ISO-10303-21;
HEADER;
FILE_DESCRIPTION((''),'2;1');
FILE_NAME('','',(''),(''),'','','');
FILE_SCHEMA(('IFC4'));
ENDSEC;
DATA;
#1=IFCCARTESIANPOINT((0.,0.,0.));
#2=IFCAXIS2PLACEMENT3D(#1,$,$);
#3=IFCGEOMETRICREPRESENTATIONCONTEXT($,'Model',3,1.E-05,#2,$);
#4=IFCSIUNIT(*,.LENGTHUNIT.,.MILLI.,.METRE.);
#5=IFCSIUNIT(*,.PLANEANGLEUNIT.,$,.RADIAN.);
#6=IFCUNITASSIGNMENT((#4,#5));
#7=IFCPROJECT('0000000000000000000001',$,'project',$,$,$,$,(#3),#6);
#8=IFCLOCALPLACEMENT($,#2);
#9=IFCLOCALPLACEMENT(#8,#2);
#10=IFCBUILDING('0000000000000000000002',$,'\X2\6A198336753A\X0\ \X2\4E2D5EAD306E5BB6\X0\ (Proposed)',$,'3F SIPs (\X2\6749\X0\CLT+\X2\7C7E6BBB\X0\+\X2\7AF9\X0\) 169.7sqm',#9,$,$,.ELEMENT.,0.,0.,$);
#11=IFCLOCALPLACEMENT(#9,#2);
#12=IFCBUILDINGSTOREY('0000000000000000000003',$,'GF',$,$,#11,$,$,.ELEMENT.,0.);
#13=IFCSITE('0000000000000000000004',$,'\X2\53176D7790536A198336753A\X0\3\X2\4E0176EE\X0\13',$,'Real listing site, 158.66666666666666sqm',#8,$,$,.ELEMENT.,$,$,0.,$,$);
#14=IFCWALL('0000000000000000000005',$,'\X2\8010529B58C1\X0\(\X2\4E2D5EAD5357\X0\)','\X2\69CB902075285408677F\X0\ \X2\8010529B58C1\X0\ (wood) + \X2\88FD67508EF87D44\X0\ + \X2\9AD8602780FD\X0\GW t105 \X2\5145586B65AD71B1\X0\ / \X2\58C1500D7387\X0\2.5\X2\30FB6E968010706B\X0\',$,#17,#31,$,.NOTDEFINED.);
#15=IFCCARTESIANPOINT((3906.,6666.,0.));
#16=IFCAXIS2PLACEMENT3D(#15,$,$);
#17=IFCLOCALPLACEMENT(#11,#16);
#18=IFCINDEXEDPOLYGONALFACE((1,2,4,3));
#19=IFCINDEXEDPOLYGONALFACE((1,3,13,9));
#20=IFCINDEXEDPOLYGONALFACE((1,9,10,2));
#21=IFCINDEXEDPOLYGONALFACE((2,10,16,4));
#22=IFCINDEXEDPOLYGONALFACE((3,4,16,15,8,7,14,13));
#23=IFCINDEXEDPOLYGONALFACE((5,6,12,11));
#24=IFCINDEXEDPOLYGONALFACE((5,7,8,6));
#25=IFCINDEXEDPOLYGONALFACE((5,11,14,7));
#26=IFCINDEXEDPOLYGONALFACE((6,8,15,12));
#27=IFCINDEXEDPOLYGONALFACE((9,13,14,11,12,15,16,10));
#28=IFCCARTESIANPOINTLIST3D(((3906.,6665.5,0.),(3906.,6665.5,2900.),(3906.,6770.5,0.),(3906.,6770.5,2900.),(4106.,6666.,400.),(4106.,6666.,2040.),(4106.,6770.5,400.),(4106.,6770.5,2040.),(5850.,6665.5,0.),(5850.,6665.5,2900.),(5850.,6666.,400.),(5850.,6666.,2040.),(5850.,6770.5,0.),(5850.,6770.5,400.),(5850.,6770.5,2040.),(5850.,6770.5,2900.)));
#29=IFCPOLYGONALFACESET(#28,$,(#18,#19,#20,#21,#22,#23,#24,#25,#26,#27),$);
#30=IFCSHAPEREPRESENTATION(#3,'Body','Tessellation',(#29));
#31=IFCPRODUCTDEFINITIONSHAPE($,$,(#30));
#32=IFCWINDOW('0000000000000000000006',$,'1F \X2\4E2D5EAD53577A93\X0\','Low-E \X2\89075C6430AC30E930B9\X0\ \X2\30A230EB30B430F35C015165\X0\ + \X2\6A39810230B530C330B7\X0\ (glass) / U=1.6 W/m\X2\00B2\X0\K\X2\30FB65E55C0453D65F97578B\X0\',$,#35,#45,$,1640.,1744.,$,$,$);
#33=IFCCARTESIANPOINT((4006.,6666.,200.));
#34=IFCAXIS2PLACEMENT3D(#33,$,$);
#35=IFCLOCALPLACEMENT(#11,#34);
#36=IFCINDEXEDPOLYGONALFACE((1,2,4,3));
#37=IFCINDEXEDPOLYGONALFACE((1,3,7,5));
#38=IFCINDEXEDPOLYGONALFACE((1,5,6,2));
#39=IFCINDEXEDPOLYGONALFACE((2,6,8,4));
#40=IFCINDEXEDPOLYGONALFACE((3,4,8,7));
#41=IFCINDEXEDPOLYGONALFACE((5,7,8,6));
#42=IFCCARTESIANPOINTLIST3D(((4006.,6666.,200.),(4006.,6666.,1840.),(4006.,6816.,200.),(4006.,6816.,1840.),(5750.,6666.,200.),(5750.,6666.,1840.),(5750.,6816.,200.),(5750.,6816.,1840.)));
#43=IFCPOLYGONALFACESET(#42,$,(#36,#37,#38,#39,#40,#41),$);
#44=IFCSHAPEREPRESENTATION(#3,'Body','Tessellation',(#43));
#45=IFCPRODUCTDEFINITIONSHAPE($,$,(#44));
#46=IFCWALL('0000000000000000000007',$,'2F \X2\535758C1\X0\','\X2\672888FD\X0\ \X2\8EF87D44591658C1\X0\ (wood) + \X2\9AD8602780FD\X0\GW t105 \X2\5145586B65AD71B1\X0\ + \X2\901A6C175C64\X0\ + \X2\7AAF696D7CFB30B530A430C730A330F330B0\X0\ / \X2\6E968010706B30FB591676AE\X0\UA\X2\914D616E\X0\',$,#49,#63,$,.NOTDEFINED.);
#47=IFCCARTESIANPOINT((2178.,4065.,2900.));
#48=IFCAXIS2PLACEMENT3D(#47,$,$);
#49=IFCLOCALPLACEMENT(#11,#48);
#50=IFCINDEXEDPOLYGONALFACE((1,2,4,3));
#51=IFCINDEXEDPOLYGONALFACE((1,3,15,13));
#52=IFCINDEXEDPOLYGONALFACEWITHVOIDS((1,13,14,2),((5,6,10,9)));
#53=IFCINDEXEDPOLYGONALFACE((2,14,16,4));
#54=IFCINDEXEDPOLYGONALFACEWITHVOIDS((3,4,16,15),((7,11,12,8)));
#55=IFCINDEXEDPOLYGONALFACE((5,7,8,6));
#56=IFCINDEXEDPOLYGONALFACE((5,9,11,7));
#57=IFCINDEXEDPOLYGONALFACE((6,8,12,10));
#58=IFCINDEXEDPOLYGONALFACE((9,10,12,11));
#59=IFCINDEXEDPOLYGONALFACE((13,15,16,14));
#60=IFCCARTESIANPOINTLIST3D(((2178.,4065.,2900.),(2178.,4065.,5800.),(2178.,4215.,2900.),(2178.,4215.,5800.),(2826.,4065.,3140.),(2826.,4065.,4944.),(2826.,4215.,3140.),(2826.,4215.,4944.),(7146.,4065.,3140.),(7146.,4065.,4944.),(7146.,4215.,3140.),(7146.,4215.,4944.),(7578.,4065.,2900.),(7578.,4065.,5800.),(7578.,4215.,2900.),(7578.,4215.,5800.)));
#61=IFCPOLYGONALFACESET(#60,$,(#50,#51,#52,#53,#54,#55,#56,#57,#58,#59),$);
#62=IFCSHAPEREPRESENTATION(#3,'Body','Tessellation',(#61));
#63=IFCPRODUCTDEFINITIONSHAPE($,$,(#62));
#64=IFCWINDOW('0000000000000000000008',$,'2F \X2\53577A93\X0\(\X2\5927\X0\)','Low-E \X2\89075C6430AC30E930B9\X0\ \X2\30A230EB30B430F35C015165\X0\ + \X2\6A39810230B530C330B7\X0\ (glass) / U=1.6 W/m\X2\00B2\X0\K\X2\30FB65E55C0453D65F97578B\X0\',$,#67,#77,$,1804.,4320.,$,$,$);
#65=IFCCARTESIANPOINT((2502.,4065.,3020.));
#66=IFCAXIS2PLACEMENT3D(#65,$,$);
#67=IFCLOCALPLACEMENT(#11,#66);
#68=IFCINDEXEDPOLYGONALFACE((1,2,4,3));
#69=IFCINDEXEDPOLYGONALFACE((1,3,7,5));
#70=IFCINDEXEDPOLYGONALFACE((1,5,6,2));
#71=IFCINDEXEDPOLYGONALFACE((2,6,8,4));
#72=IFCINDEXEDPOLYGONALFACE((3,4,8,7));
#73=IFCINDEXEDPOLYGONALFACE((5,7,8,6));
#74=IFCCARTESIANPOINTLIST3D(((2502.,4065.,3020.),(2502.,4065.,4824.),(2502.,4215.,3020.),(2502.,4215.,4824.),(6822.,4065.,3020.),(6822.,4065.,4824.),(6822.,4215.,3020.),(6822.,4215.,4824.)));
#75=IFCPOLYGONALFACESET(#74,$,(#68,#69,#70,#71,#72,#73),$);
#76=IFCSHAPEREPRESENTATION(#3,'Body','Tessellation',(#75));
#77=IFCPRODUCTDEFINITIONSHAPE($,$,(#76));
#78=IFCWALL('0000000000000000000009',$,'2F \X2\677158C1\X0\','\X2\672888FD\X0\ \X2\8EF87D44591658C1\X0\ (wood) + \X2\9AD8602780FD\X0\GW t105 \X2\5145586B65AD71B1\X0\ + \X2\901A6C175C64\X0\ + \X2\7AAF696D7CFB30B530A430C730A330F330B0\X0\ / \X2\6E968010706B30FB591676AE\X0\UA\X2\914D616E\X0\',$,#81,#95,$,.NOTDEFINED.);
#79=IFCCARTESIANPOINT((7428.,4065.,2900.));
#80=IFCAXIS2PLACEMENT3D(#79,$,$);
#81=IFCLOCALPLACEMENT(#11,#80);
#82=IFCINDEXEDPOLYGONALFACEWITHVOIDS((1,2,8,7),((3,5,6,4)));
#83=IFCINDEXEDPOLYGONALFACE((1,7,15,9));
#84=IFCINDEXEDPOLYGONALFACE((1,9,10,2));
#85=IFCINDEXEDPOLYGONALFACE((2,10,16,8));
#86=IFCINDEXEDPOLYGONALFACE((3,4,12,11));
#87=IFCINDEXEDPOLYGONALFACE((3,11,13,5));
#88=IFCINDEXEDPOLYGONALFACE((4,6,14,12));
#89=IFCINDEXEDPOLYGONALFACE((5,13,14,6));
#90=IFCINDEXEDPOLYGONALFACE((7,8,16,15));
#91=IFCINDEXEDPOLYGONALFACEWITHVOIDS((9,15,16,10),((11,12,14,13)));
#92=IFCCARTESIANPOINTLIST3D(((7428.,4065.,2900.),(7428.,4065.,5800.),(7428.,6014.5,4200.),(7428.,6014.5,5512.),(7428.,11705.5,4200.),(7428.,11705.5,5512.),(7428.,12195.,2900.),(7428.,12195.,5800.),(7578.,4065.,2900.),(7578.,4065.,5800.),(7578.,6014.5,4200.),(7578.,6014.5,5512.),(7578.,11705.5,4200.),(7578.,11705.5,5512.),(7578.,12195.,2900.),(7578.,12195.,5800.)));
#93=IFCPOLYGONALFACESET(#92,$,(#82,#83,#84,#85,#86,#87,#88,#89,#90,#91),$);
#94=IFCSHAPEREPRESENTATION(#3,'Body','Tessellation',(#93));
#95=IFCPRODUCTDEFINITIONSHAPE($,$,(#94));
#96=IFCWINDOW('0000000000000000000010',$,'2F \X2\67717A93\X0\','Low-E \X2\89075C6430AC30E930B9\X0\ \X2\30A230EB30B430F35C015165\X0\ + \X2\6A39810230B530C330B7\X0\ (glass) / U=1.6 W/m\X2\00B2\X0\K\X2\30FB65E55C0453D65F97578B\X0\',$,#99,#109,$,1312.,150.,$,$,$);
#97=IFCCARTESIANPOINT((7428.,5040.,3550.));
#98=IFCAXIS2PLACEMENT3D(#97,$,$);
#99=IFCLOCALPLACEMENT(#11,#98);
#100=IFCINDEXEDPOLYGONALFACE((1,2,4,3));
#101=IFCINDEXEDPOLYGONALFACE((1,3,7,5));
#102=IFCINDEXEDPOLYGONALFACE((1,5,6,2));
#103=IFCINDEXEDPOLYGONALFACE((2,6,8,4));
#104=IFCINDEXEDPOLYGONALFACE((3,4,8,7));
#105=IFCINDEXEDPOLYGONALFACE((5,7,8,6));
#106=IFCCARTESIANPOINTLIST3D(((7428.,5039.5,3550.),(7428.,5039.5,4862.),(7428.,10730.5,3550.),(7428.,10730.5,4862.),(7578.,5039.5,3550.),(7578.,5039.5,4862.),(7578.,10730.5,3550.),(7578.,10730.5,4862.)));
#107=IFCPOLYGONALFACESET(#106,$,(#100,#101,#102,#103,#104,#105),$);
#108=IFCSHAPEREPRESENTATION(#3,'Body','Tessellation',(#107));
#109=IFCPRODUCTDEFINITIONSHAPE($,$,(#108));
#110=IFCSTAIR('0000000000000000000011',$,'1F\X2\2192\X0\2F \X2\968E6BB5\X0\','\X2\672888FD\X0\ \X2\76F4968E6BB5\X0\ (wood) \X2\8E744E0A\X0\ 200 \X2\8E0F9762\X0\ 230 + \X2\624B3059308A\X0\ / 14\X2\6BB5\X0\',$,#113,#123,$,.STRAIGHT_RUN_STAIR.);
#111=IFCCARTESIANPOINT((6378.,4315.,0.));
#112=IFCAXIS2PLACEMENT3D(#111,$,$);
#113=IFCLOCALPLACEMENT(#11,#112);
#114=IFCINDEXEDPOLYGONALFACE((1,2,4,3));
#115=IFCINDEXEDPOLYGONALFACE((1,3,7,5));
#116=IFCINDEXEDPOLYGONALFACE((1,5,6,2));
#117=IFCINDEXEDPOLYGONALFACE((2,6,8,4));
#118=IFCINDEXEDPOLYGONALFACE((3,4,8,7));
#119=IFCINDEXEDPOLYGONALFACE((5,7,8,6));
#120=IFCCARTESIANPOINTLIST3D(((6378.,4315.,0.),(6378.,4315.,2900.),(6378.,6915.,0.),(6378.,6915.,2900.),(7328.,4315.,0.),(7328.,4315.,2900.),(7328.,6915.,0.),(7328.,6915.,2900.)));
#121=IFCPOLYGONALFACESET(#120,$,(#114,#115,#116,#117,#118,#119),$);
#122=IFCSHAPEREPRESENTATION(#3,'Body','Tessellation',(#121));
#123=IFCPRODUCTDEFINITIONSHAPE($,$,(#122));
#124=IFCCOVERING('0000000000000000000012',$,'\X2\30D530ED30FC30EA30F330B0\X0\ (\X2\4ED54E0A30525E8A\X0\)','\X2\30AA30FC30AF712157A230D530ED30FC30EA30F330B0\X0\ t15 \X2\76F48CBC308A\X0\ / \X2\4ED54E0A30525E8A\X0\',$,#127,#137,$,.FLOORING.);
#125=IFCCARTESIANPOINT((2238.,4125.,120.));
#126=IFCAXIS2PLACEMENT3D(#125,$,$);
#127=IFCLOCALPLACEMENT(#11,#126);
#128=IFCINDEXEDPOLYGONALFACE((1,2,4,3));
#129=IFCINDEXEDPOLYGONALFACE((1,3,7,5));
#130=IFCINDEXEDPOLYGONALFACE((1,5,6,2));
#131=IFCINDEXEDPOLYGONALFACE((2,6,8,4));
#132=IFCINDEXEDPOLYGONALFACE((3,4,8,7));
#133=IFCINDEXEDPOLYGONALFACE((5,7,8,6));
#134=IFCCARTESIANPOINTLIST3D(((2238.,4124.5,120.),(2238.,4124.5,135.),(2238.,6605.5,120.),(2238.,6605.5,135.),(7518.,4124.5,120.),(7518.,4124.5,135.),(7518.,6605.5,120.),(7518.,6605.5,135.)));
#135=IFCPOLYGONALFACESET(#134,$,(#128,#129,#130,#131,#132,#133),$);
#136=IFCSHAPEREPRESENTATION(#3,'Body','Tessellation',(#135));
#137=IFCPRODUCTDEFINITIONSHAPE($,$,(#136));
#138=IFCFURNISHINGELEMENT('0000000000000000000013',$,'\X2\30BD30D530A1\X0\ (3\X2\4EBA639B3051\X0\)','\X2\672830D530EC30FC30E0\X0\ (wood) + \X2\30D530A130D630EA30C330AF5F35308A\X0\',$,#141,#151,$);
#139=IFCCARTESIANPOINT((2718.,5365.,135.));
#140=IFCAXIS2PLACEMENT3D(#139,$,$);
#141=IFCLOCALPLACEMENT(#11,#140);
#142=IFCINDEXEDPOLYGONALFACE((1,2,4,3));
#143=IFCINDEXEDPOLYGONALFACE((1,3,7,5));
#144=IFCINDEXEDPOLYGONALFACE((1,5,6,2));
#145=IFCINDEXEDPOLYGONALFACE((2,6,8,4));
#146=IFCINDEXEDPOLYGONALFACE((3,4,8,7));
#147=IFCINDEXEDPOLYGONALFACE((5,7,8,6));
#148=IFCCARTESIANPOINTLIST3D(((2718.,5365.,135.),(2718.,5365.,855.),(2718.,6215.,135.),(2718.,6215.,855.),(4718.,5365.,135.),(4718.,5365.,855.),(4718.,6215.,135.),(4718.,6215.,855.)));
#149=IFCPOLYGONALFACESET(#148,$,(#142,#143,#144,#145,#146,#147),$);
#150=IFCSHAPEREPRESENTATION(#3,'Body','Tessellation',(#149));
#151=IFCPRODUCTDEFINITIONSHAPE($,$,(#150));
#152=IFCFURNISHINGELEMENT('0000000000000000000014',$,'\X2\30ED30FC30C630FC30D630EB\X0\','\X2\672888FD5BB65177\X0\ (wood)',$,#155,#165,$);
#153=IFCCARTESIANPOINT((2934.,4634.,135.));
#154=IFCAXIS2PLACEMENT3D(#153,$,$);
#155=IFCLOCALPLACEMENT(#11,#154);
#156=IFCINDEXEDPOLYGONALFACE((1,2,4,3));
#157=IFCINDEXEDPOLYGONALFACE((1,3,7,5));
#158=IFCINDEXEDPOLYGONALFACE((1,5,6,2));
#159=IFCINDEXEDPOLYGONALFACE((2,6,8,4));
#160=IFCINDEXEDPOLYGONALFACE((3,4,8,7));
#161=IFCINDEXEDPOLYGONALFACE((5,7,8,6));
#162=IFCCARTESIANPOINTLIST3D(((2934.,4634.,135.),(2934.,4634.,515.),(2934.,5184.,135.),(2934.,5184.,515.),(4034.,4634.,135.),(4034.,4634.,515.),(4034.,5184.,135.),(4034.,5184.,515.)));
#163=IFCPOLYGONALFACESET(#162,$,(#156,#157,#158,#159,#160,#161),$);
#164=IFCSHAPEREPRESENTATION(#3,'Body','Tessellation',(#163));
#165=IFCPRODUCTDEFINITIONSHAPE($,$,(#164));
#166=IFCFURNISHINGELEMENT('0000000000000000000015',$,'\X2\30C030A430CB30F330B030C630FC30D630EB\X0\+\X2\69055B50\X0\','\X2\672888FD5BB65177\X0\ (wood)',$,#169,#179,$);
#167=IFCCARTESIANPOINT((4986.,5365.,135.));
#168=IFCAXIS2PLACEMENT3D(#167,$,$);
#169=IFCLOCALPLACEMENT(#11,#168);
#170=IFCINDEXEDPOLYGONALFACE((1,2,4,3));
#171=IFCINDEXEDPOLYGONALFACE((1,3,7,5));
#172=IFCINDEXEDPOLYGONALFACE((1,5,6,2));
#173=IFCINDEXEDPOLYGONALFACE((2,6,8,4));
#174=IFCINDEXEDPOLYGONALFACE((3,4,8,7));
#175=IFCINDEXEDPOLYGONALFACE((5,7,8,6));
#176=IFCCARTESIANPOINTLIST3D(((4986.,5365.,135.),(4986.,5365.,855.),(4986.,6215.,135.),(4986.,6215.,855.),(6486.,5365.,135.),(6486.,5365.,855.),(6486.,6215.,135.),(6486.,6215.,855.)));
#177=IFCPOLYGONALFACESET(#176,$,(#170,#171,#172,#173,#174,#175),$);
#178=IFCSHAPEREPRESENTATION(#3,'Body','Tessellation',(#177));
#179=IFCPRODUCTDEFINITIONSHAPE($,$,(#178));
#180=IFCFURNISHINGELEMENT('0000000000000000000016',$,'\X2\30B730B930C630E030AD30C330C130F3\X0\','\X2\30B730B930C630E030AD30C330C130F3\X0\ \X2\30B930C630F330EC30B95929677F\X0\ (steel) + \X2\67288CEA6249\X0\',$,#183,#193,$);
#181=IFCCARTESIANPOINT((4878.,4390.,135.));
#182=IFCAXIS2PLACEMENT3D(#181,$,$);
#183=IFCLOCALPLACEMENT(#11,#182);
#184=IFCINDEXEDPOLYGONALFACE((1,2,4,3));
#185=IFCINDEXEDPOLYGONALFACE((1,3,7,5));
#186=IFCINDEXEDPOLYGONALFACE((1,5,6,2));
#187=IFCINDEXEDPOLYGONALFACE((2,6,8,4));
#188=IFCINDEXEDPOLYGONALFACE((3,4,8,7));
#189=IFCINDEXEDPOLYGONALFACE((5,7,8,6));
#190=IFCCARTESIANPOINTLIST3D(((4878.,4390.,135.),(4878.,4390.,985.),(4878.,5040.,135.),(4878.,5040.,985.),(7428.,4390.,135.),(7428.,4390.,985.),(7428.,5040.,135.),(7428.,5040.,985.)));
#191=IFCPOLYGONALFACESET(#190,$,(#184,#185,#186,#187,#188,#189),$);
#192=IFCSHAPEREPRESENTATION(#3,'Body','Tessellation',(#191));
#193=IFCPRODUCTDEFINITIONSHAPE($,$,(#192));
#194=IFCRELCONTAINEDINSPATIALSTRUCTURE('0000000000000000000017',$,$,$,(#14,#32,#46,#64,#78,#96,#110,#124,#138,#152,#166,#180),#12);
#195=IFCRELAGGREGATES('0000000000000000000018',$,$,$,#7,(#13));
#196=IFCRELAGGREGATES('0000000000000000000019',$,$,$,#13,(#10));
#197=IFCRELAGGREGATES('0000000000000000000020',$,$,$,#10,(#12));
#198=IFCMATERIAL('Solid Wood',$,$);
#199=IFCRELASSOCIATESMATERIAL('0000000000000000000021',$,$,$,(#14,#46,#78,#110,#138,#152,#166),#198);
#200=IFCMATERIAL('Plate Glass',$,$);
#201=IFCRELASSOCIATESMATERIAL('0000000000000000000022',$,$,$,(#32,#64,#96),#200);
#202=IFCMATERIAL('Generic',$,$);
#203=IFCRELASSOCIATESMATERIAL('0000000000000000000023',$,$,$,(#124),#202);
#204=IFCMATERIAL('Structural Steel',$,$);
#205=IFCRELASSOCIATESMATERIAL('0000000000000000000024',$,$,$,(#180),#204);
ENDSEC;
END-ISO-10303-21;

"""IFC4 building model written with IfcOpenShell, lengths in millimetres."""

from ifc_helpers import new_model, si_unit, frame, frame_2d, origin, place, context, project, spatial, rectangle, extrude, material, element, fill, save


model = new_model("IFC4")

# Units and contexts
model_context = context("Model", 3, precision=1e-05, world=origin())
ifc_project = project(units=[si_unit("LENGTHUNIT", "METRE", prefix="MILLI"), si_unit("PLANEANGLEUNIT", "RADIAN")], contexts=[model_context])

# Site, building, storey
site_placement = place(None, origin())
site = spatial("IfcSite", under=ifc_project, at=site_placement, Name="北海道標茶町3丁目13", ObjectType="Real listing site, 158.66666666666666sqm", CompositionType="ELEMENT", RefElevation=0.0)
building_placement = place(site_placement, origin())
building = spatial("IfcBuilding", under=site, at=building_placement, Name="標茶町 中庭の家 (Proposed)", ObjectType="3F SIPs (杉CLT+籾殻+竹) 169.7sqm", CompositionType="ELEMENT", ElevationOfRefHeight=0.0, ElevationOfTerrain=0.0)
storey_placement = place(building_placement, origin())
storey = spatial("IfcBuildingStorey", under=building, at=storey_placement, Name="GF", CompositionType="ELEMENT", Elevation=0.0)

# Shared definitions
ifc_material_1 = material(Name="Solid Wood")
ifc_material_2 = material(Name="Generic")

# Shared definitions
ifc_material_3 = material(Name="Plate Glass")

# Wall, opening, window
wall_1_placement = place(storey_placement, frame((3906.0, 6666.0, 0.0)))
wall_1 = element("IfcWall", 1, at=wall_1_placement, inside=storey, material=ifc_material_1, Name="耐力壁(中庭南)", Description="構造用合板 耐力壁 (wood) + 製材軸組 + 高性能GW t105 充填断熱 / 壁倍率2.5・準耐火", PredefinedType="NOTDEFINED", context=model_context, shape_type="SweptSolid", body=[
    extrude(rectangle(XDim=1944.0, YDim=105.0, at=frame_2d((972.0, 52.0))), frame((3906.0, 6666.0, 0.0)), (0.0, 0.0, 1.0), 2900.0),
])
opening_1_placement = place(storey_placement, frame((4006.0, 6666.0, 200.0)))
opening_1 = element("IfcOpeningElement", 2, at=opening_1_placement, cuts=wall_1, PredefinedType="NOTDEFINED", context=model_context, shape_type="SweptSolid", body=[
    extrude(rectangle(XDim=1744.0, YDim=150.0, at=frame_2d((872.0, 75.0))), frame((4006.0, 6666.0, 200.0)), (0.0, 0.0, 1.0), 1640.0),
])
window_1_placement = place(storey_placement, frame((4006.0, 6666.0, 200.0)))
window_1 = element("IfcWindow", 3, at=window_1_placement, inside=storey, material=ifc_material_3, Name="1F 中庭南窓", Description="Low-E 複層ガラス アルゴン封入 + 樹脂サッシ (glass) / U=1.6 W/m²K・日射取得型", OverallHeight=1640.0, OverallWidth=1744.0, context=model_context, shape_type="SweptSolid", body=[
    extrude(rectangle(XDim=1744.0, YDim=150.0, at=frame_2d((872.0, 75.0))), frame((4006.0, 6666.0, 200.0)), (0.0, 0.0, 1.0), 1640.0),
])
fill(opening_1, window_1)

# Walls, openings, windows
wall_2_placement = place(storey_placement, frame((2178.0, 4065.0, 2900.0)))
wall_2 = element("IfcWall", 4, at=wall_2_placement, inside=storey, material=ifc_material_1, Name="2F 南壁", Description="木製 軸組外壁 (wood) + 高性能GW t105 充填断熱 + 通気層 + 窯業系サイディング / 準耐火・外皮UA配慮", PredefinedType="NOTDEFINED", context=model_context, shape_type="SweptSolid", body=[
    extrude(rectangle(XDim=5400.0, YDim=150.0, at=frame_2d((2700.0, 75.0))), frame((2178.0, 4065.0, 2900.0)), (0.0, 0.0, 1.0), 2900.0),
])
opening_2_placement = place(storey_placement, frame((2502.0, 4065.0, 3020.0)))
opening_2 = element("IfcOpeningElement", 5, at=opening_2_placement, cuts=wall_2, PredefinedType="NOTDEFINED", context=model_context, shape_type="SweptSolid", body=[
    extrude(rectangle(XDim=4320.0, YDim=150.0, at=frame_2d((2160.0, 75.0))), frame((2502.0, 4065.0, 3020.0)), (0.0, 0.0, 1.0), 1804.0),
])
window_2_placement = place(storey_placement, frame((2502.0, 4065.0, 3020.0)))
window_2 = element("IfcWindow", 6, at=window_2_placement, inside=storey, material=ifc_material_3, Name="2F 南窓(大)", Description="Low-E 複層ガラス アルゴン封入 + 樹脂サッシ (glass) / U=1.6 W/m²K・日射取得型", OverallHeight=1804.0, OverallWidth=4320.0, context=model_context, shape_type="SweptSolid", body=[
    extrude(rectangle(XDim=4320.0, YDim=150.0, at=frame_2d((2160.0, 75.0))), frame((2502.0, 4065.0, 3020.0)), (0.0, 0.0, 1.0), 1804.0),
])
fill(opening_2, window_2)
wall_3_placement = place(storey_placement, frame((7428.0, 4065.0, 2900.0)))
wall_3 = element("IfcWall", 7, at=wall_3_placement, inside=storey, material=ifc_material_1, Name="2F 東壁", Description="木製 軸組外壁 (wood) + 高性能GW t105 充填断熱 + 通気層 + 窯業系サイディング / 準耐火・外皮UA配慮", PredefinedType="NOTDEFINED", context=model_context, shape_type="SweptSolid", body=[
    extrude(rectangle(XDim=150.0, YDim=8130.0, at=frame_2d((75.0, 4065.0))), frame((7428.0, 4065.0, 2900.0)), (0.0, 0.0, 1.0), 2900.0),
])
opening_3_placement = place(storey_placement, frame((7428.0, 5040.0, 3550.0)))
opening_3 = element("IfcOpeningElement", 8, at=opening_3_placement, cuts=wall_3, PredefinedType="NOTDEFINED", context=model_context, shape_type="SweptSolid", body=[
    extrude(rectangle(XDim=150.0, YDim=5691.0, at=frame_2d((75.0, 2845.0))), frame((7428.0, 5040.0, 3550.0)), (0.0, 0.0, 1.0), 1312.0),
])
window_3_placement = place(storey_placement, frame((7428.0, 5040.0, 3550.0)))
window_3 = element("IfcWindow", 9, at=window_3_placement, inside=storey, material=ifc_material_3, Name="2F 東窓", Description="Low-E 複層ガラス アルゴン封入 + 樹脂サッシ (glass) / U=1.6 W/m²K・日射取得型", OverallHeight=1312.0, OverallWidth=150.0, context=model_context, shape_type="SweptSolid", body=[
    extrude(rectangle(XDim=150.0, YDim=5691.0, at=frame_2d((75.0, 2845.0))), frame((7428.0, 5040.0, 3550.0)), (0.0, 0.0, 1.0), 1312.0),
])
fill(opening_3, window_3)

# Stair
stair_placement = place(storey_placement, frame((6378.0, 4315.0, 0.0)))
element("IfcStair", 10, at=stair_placement, inside=storey, material=ifc_material_1, Name="1F→2F 階段", Description="木製 直階段 (wood) 蹴上 200 踏面 230 + 手すり / 14段", PredefinedType="STRAIGHT_RUN_STAIR", context=model_context, shape_type="SweptSolid", body=[
    extrude(rectangle(XDim=950.0, YDim=2600.0, at=frame_2d((475.0, 1300.0))), frame((6378.0, 4315.0, 0.0)), (0.0, 0.0, 1.0), 2900.0),
])

# Covering
covering_placement = place(storey_placement, frame((2238.0, 4125.0, 120.0)))
element("IfcCovering", 11, at=covering_placement, inside=storey, material=ifc_material_2, Name="フローリング (仕上げ床)", Description="オーク無垢フローリング t15 直貼り / 仕上げ床", PredefinedType="FLOORING", context=model_context, shape_type="SweptSolid", body=[
    extrude(rectangle(XDim=5280.0, YDim=2481.0, at=frame_2d((2640.0, 1240.0))), frame((2238.0, 4125.0, 120.0)), (0.0, 0.0, 1.0), 15.0),
])

# Furnishing elements
furnishing_1_placement = place(storey_placement, frame((2718.0, 5365.0, 135.0)))
element("IfcFurnishingElement", 12, at=furnishing_1_placement, inside=storey, material=ifc_material_1, Name="ソファ (3人掛け)", Description="木フレーム (wood) + ファブリック張り", context=model_context, shape_type="SweptSolid", body=[
    extrude(rectangle(XDim=2000.0, YDim=850.0, at=frame_2d((1000.0, 425.0))), frame((2718.0, 5365.0, 135.0)), (0.0, 0.0, 1.0), 720.0),
])
furnishing_2_placement = place(storey_placement, frame((2934.0, 4634.0, 135.0)))
element("IfcFurnishingElement", 13, at=furnishing_2_placement, inside=storey, material=ifc_material_1, Name="ローテーブル", Description="木製家具 (wood)", context=model_context, shape_type="SweptSolid", body=[
    extrude(rectangle(XDim=1100.0, YDim=550.0, at=frame_2d((550.0, 275.0))), frame((2934.0, 4634.0, 135.0)), (0.0, 0.0, 1.0), 380.0),
])
furnishing_3_placement = place(storey_placement, frame((4986.0, 5365.0, 135.0)))
element("IfcFurnishingElement", 14, at=furnishing_3_placement, inside=storey, material=ifc_material_1, Name="ダイニングテーブル+椅子", Description="木製家具 (wood)", context=model_context, shape_type="SweptSolid", body=[
    extrude(rectangle(XDim=1500.0, YDim=850.0, at=frame_2d((750.0, 425.0))), frame((4986.0, 5365.0, 135.0)), (0.0, 0.0, 1.0), 720.0),
])
ifc_material_4 = material(Name="Structural Steel")
furnishing_4_placement = place(storey_placement, frame((4878.0, 4390.0, 135.0)))
element("IfcFurnishingElement", 15, at=furnishing_4_placement, inside=storey, material=ifc_material_4, Name="システムキッチン", Description="システムキッチン ステンレス天板 (steel) + 木質扉", context=model_context, shape_type="SweptSolid", body=[
    extrude(rectangle(XDim=2550.0, YDim=650.0, at=frame_2d((1275.0, 325.0))), frame((4878.0, 4390.0, 135.0)), (0.0, 0.0, 1.0), 850.0),
])

save(model, "model.ifc")
